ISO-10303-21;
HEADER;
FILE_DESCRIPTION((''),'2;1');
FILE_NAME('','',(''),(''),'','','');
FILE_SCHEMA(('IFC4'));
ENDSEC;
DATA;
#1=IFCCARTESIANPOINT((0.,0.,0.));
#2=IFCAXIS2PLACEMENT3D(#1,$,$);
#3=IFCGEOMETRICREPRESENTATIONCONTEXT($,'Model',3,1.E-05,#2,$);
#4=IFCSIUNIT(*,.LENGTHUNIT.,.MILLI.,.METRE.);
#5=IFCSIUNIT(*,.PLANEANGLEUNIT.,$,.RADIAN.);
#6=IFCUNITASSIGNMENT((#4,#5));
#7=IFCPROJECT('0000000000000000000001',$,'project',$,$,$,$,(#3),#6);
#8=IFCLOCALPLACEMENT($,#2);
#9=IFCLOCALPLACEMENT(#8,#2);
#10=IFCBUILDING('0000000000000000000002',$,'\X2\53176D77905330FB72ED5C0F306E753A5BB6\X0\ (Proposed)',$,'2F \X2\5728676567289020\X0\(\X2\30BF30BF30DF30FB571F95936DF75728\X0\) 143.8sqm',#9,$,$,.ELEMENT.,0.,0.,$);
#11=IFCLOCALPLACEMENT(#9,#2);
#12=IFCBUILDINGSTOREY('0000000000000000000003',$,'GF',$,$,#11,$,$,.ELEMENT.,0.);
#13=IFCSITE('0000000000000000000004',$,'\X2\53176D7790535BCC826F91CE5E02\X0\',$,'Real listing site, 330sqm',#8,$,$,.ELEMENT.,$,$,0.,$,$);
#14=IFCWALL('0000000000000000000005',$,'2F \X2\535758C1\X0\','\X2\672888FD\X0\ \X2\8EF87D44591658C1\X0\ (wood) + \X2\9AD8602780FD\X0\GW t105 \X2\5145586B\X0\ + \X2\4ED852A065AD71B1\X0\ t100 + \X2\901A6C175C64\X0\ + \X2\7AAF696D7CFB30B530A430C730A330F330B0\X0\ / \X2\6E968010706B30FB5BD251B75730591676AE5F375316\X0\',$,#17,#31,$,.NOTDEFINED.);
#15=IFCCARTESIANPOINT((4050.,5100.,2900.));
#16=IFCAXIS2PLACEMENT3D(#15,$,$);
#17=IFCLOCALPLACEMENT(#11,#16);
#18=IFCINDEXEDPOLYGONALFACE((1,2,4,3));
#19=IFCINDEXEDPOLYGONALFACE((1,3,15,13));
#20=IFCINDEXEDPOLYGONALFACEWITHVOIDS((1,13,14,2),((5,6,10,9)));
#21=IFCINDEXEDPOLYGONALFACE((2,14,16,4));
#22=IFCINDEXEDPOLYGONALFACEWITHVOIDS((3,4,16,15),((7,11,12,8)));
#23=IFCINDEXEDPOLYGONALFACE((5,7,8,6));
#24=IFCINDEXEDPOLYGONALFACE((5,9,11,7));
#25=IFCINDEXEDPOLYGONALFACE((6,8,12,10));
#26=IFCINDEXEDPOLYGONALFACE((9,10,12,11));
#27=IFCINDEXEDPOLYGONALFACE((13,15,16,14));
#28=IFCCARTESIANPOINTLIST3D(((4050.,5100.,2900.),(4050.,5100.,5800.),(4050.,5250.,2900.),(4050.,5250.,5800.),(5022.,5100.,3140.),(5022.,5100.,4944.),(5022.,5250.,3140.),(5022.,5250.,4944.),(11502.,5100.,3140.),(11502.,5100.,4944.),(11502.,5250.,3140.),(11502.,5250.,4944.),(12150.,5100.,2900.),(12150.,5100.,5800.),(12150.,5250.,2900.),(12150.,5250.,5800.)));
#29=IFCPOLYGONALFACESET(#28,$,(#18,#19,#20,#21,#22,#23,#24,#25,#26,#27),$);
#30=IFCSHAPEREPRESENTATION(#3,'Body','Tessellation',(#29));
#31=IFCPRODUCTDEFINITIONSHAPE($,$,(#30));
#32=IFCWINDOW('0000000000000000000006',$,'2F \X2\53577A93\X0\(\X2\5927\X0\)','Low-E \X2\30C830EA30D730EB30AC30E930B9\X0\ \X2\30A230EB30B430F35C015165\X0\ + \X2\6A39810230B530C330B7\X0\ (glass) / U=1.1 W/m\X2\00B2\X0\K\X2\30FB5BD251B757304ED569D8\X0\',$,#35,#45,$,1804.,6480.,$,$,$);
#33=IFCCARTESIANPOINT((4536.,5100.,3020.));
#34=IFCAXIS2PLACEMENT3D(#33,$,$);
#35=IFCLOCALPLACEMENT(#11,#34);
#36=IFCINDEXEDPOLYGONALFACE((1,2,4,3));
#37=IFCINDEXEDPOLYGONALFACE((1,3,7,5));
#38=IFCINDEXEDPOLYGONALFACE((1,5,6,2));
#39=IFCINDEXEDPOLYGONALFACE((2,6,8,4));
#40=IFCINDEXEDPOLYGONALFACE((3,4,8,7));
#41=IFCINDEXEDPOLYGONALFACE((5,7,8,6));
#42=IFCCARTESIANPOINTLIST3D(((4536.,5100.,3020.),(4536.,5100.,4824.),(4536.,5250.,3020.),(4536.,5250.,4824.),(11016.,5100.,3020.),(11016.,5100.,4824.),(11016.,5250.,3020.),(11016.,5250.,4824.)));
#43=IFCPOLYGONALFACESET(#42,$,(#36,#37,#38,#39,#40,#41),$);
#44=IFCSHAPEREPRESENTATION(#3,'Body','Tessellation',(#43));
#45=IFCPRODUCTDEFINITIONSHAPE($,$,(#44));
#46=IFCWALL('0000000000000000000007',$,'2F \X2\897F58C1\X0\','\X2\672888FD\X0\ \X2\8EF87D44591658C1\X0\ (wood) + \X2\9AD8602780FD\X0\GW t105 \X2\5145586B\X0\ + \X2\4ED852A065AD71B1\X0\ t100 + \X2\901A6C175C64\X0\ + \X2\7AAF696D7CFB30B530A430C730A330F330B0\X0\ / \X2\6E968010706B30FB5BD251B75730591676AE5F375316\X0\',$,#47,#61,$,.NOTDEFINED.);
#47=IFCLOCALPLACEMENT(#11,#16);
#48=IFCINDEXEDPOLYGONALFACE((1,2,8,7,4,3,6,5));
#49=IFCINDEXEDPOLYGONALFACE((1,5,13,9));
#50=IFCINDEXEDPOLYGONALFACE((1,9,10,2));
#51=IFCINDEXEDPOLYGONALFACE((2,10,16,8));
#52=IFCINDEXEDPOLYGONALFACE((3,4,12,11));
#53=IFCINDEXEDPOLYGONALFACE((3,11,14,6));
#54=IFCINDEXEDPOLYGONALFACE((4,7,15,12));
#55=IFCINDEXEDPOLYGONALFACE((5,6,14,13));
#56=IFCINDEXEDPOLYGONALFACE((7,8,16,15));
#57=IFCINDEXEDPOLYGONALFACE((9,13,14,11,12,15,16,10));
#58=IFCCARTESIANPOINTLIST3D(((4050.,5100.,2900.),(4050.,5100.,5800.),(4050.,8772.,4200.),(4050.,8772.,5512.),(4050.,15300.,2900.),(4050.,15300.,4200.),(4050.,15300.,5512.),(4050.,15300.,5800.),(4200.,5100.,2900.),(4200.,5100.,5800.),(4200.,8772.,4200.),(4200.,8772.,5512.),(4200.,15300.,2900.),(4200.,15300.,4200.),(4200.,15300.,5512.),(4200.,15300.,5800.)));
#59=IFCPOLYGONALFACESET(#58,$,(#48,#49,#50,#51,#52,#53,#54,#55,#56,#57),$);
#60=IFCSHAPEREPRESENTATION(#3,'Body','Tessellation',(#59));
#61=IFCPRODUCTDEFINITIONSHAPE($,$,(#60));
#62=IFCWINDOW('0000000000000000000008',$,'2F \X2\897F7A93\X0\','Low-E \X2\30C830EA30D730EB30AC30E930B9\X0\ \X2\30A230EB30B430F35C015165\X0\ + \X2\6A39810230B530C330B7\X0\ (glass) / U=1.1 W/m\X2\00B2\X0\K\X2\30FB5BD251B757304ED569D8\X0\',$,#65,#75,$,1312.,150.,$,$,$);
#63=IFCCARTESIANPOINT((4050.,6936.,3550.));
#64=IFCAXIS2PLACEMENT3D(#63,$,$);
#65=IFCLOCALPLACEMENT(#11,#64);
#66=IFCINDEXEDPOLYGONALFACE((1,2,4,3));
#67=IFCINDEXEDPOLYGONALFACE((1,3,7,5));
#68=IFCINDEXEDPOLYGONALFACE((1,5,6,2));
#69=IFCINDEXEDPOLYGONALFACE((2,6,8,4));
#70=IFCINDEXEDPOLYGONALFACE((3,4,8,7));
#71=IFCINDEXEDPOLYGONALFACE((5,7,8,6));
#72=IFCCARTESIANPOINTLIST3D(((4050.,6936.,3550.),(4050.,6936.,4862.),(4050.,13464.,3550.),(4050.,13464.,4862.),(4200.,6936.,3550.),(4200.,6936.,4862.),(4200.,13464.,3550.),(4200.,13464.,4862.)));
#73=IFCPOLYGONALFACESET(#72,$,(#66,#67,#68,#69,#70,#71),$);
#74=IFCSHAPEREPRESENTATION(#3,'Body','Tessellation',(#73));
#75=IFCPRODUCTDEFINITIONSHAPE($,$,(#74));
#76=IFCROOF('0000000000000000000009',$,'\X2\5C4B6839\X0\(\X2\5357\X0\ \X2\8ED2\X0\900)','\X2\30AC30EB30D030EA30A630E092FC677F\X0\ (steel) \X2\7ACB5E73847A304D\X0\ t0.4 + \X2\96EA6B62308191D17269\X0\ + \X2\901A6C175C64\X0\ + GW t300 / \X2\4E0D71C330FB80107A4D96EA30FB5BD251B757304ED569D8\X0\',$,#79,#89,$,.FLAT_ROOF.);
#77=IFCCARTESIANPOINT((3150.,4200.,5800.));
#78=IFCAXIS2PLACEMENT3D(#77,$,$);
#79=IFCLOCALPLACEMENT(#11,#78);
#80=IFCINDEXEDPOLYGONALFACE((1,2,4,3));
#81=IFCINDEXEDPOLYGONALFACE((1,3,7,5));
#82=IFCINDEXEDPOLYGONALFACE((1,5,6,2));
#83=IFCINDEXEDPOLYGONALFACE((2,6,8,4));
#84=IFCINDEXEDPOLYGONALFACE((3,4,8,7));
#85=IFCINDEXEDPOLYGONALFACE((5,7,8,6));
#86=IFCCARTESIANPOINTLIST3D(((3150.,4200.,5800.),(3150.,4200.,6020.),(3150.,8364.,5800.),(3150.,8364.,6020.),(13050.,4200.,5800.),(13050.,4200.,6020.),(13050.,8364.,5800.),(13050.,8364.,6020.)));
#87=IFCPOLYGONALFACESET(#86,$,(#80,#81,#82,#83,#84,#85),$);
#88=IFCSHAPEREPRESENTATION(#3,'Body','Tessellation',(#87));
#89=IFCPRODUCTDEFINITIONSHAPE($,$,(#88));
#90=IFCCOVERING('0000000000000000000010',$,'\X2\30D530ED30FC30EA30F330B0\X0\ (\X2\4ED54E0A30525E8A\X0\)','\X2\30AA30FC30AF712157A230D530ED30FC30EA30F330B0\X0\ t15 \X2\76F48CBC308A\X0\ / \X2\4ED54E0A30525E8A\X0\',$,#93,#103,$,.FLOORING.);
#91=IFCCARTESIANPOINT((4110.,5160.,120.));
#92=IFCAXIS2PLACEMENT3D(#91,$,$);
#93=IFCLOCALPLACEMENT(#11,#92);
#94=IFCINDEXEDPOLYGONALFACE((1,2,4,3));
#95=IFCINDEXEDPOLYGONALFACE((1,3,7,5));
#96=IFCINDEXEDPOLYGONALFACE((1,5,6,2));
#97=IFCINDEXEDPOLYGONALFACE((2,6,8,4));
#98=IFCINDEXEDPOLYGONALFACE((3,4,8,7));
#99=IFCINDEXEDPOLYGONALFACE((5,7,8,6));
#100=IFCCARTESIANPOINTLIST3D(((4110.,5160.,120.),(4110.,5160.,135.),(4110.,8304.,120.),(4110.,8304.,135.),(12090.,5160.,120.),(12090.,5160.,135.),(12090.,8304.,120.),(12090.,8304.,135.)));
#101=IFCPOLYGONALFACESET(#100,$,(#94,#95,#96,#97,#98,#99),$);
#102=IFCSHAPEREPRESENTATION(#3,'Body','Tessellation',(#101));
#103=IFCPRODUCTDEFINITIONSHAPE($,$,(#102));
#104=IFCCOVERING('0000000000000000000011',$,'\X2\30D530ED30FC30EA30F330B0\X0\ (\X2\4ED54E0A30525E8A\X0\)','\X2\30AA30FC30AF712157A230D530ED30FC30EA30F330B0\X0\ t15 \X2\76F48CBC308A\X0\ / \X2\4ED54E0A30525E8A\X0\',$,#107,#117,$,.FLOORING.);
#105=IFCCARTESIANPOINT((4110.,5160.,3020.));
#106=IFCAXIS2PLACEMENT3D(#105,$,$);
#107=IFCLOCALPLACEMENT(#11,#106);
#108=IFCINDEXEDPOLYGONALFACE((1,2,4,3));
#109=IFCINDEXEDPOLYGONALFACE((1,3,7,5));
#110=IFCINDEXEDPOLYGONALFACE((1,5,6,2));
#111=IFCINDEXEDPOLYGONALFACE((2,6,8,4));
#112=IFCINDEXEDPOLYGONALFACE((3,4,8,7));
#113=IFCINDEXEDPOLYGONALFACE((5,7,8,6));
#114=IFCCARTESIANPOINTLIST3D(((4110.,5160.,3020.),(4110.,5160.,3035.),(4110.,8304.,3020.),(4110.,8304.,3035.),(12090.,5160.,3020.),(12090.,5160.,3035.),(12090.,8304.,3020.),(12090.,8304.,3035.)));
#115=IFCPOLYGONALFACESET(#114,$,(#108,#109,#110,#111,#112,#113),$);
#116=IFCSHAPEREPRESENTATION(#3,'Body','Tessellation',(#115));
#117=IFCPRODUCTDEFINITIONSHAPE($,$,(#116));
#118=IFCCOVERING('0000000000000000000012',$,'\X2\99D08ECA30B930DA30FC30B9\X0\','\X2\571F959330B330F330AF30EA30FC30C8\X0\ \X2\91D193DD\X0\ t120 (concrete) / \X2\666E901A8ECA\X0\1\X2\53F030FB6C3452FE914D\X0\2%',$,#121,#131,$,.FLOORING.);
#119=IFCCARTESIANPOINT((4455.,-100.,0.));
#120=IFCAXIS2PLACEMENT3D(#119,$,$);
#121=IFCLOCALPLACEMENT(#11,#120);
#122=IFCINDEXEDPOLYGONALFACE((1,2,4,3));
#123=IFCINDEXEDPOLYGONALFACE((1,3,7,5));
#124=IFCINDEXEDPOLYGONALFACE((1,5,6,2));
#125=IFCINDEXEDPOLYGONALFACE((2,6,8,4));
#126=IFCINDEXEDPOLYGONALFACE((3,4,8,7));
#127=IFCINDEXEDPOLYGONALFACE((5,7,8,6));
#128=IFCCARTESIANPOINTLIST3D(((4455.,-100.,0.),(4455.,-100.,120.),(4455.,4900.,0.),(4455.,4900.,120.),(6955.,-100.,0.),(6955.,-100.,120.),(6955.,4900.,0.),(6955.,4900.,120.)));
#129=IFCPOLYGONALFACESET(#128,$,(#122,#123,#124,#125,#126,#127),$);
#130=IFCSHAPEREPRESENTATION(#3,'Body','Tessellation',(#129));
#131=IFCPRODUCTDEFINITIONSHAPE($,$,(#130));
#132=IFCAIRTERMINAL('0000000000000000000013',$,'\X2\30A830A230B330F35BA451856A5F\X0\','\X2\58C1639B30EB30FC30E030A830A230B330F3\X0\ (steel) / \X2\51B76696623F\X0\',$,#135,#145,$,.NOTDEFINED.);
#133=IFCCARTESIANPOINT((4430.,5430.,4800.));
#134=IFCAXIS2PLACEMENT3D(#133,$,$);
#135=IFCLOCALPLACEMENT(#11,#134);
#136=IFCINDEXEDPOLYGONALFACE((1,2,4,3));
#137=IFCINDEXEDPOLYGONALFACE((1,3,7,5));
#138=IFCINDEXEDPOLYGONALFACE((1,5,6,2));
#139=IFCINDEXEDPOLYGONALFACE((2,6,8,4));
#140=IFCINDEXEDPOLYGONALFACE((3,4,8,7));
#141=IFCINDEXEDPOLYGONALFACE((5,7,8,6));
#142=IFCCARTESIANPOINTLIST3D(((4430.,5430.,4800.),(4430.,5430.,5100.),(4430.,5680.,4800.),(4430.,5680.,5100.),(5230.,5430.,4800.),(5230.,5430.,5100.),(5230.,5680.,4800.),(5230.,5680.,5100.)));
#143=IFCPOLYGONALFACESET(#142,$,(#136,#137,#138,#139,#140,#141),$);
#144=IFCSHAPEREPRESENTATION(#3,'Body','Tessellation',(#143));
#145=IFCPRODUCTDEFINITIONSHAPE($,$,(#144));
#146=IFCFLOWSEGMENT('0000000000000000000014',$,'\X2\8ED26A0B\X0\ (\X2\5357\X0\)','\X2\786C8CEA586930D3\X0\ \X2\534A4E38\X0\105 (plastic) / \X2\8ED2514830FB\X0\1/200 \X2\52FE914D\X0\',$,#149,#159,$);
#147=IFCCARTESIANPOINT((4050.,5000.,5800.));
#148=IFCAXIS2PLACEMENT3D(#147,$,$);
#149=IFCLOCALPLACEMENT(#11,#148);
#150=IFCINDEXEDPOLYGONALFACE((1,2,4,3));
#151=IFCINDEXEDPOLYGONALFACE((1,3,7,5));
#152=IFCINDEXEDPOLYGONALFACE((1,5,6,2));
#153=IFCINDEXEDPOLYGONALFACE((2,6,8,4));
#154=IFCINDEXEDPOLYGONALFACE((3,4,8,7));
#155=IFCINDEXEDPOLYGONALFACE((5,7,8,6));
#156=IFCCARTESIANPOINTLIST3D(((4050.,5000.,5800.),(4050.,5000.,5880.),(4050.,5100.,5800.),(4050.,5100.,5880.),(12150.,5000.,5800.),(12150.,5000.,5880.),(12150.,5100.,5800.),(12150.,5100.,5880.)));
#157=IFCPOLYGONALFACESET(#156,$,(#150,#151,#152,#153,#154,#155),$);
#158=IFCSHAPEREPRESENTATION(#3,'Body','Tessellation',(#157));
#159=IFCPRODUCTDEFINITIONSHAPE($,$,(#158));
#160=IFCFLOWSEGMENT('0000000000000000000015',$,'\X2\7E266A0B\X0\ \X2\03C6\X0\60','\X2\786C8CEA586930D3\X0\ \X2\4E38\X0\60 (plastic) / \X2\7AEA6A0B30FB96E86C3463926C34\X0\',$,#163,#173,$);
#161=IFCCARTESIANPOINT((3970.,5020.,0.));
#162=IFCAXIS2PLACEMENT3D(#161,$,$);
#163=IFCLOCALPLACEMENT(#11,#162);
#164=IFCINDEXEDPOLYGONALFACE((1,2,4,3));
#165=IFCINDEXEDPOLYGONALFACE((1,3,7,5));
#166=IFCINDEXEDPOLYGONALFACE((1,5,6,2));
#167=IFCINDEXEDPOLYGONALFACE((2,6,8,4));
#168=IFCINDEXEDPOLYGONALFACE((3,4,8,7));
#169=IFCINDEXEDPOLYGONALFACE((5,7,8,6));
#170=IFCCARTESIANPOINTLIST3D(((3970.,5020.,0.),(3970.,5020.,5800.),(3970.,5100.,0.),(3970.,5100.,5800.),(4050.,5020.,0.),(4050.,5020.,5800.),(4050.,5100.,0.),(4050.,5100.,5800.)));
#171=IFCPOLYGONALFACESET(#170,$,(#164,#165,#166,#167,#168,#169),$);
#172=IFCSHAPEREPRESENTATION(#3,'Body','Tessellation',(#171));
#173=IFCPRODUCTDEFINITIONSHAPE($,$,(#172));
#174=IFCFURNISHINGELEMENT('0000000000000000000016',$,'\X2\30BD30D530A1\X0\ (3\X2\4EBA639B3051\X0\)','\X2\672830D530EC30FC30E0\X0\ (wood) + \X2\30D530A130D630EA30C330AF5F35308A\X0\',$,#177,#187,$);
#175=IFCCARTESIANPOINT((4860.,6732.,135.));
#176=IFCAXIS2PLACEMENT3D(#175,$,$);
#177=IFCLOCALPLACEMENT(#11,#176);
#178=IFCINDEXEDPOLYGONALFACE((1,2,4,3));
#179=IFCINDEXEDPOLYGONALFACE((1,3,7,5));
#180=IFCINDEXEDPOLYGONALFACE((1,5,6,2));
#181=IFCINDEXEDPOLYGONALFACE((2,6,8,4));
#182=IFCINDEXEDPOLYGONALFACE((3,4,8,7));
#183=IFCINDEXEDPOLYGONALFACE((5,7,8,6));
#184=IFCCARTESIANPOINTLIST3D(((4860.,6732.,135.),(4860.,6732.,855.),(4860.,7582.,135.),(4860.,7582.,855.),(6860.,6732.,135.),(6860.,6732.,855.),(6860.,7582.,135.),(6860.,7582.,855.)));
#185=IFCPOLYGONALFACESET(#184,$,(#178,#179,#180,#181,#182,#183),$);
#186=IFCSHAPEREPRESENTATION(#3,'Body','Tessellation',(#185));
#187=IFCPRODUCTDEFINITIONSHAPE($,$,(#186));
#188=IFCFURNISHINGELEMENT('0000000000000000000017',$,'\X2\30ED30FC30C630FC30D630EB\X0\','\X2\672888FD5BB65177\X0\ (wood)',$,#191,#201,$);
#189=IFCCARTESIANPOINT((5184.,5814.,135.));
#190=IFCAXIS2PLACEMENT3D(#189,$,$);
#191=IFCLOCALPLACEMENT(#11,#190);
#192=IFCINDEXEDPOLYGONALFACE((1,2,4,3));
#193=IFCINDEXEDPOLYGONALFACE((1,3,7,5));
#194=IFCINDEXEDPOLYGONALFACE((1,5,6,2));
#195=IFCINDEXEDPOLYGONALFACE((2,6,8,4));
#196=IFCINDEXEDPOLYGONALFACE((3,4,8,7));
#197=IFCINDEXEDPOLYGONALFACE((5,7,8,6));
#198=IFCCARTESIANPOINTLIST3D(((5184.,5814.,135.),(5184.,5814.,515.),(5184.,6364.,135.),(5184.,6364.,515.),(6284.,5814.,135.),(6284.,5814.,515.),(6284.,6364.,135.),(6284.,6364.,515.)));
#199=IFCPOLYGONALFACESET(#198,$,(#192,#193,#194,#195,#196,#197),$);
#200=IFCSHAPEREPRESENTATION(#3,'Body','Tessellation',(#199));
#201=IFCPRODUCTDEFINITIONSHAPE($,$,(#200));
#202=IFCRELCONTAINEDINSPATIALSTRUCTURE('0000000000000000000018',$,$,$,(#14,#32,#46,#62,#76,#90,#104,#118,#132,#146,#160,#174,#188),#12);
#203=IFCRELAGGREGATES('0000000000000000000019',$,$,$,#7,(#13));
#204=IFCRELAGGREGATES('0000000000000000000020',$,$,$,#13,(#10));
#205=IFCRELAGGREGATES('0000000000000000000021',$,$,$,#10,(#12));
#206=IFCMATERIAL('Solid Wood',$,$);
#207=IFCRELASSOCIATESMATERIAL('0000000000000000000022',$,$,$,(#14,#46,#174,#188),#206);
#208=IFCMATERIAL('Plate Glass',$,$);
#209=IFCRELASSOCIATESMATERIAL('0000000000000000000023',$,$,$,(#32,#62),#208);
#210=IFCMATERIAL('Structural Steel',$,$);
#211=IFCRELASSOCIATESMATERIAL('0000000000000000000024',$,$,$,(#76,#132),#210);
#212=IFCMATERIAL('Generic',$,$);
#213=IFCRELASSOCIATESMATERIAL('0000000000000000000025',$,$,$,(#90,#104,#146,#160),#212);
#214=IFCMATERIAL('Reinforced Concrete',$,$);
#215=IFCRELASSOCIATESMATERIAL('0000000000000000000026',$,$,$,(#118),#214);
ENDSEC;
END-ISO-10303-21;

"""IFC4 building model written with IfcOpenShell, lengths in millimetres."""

from ifc_helpers import new_model, si_unit, frame, frame_2d, origin, place, context, project, spatial, rectangle, extrude, material, element, fill, save


model = new_model("IFC4")

# Units and contexts
model_context = context("Model", 3, precision=1e-05, world=origin())
ifc_project = project(units=[si_unit("LENGTHUNIT", "METRE", prefix="MILLI"), si_unit("PLANEANGLEUNIT", "RADIAN")], contexts=[model_context])

# Site, building, storey
site_placement = place(None, origin())
site = spatial("IfcSite", under=ifc_project, at=site_placement, Name="北海道富良野市", ObjectType="Real listing site, 330sqm", CompositionType="ELEMENT", RefElevation=0.0)
building_placement = place(site_placement, origin())
building = spatial("IfcBuilding", under=site, at=building_placement, Name="北海道・狭小の町家 (Proposed)", ObjectType="2F 在来木造(タタミ・土間混在) 143.8sqm", CompositionType="ELEMENT", ElevationOfRefHeight=0.0, ElevationOfTerrain=0.0)
storey_placement = place(building_placement, origin())
storey = spatial("IfcBuildingStorey", under=building, at=storey_placement, Name="GF", CompositionType="ELEMENT", Elevation=0.0)

# Shared definitions
ifc_material_1 = material(Name="Solid Wood")

# Shared definitions
ifc_material_2 = material(Name="Reinforced Concrete")

# Shared definitions
ifc_material_3 = material(Name="Plate Glass")

# Walls, openings, windows
wall_1_placement = place(storey_placement, frame((4050.0, 5100.0, 2900.0)))
wall_1 = element("IfcWall", 1, at=wall_1_placement, inside=storey, material=ifc_material_1, Name="2F 南壁", Description="木製 軸組外壁 (wood) + 高性能GW t105 充填 + 付加断熱 t100 + 通気層 + 窯業系サイディング / 準耐火・寒冷地外皮強化", PredefinedType="NOTDEFINED", context=model_context, shape_type="SweptSolid", body=[
    extrude(rectangle(XDim=8100.0, YDim=150.0, at=frame_2d((4050.0, 75.0))), frame((4050.0, 5100.0, 2900.0)), (0.0, 0.0, 1.0), 2900.0),
])
opening_1_placement = place(storey_placement, frame((4536.0, 5100.0, 3020.0)))
opening_1 = element("IfcOpeningElement", 2, at=opening_1_placement, cuts=wall_1, PredefinedType="NOTDEFINED", context=model_context, shape_type="SweptSolid", body=[
    extrude(rectangle(XDim=6480.0, YDim=150.0, at=frame_2d((3240.0, 75.0))), frame((4536.0, 5100.0, 3020.0)), (0.0, 0.0, 1.0), 1804.0),
])
window_1_placement = place(storey_placement, frame((4536.0, 5100.0, 3020.0)))
window_1 = element("IfcWindow", 3, at=window_1_placement, inside=storey, material=ifc_material_3, Name="2F 南窓(大)", Description="Low-E トリプルガラス アルゴン封入 + 樹脂サッシ (glass) / U=1.1 W/m²K・寒冷地仕様", OverallHeight=1804.0, OverallWidth=6480.0, context=model_context, shape_type="SweptSolid", body=[
    extrude(rectangle(XDim=6480.0, YDim=150.0, at=frame_2d((3240.0, 75.0))), frame((4536.0, 5100.0, 3020.0)), (0.0, 0.0, 1.0), 1804.0),
])
fill(opening_1, window_1)
wall_2_placement = place(storey_placement, frame((4050.0, 5100.0, 2900.0)))
wall_2 = element("IfcWall", 4, at=wall_2_placement, inside=storey, material=ifc_material_1, Name="2F 西壁", Description="木製 軸組外壁 (wood) + 高性能GW t105 充填 + 付加断熱 t100 + 通気層 + 窯業系サイディング / 準耐火・寒冷地外皮強化", PredefinedType="NOTDEFINED", context=model_context, shape_type="SweptSolid", body=[
    extrude(rectangle(XDim=150.0, YDim=10200.0, at=frame_2d((75.0, 5100.0))), frame((4050.0, 5100.0, 2900.0)), (0.0, 0.0, 1.0), 2900.0),
])
opening_2_placement = place(storey_placement, frame((4050.0, 6936.0, 3550.0)))
opening_2 = element("IfcOpeningElement", 5, at=opening_2_placement, cuts=wall_2, PredefinedType="NOTDEFINED", context=model_context, shape_type="SweptSolid", body=[
    extrude(rectangle(XDim=150.0, YDim=6528.0, at=frame_2d((75.0, 3264.0))), frame((4050.0, 6936.0, 3550.0)), (0.0, 0.0, 1.0), 1312.0),
])
window_2_placement = place(storey_placement, frame((4050.0, 6936.0, 3550.0)))
window_2 = element("IfcWindow", 6, at=window_2_placement, inside=storey, material=ifc_material_3, Name="2F 西窓", Description="Low-E トリプルガラス アルゴン封入 + 樹脂サッシ (glass) / U=1.1 W/m²K・寒冷地仕様", OverallHeight=1312.0, OverallWidth=150.0, context=model_context, shape_type="SweptSolid", body=[
    extrude(rectangle(XDim=150.0, YDim=6528.0, at=frame_2d((75.0, 3264.0))), frame((4050.0, 6936.0, 3550.0)), (0.0, 0.0, 1.0), 1312.0),
])
fill(opening_2, window_2)

# Roof
ifc_material_4 = material(Name="Structural Steel")
for number, where, name in (
    (7, (3150.0, 4200.0, 5800.0), "屋根(南 軒900)"),
):
    element("IfcRoof", number, at=place(storey_placement, frame(where)), inside=storey, material=ifc_material_4, Name=name, Description="ガルバリウム鋼板 (steel) 立平葺き t0.4 + 雪止め金物 + 通気層 + GW t300 / 不燃・耐積雪・寒冷地仕様", PredefinedType="FLAT_ROOF", context=model_context, shape_type="SweptSolid", body=[
        extrude(rectangle(XDim=9900.0, YDim=4164.0, at=frame_2d((4950.0, 2082.0))), frame((3150.0, 4200.0, 5800.0)), (0.0, 0.0, 1.0), 220.0),
    ])

# Coverings
ifc_material_5 = material(Name="Generic")
covering_1_placement = place(storey_placement, frame((4110.0, 5160.0, 120.0)))
element("IfcCovering", 8, at=covering_1_placement, inside=storey, material=ifc_material_5, Name="フローリング (仕上げ床)", Description="オーク無垢フローリング t15 直貼り / 仕上げ床", PredefinedType="FLOORING", context=model_context, shape_type="SweptSolid", body=[
    extrude(rectangle(XDim=7980.0, YDim=3144.0, at=frame_2d((3990.0, 1572.0))), frame((4110.0, 5160.0, 120.0)), (0.0, 0.0, 1.0), 15.0),
])
covering_2_placement = place(storey_placement, frame((4110.0, 5160.0, 3020.0)))
element("IfcCovering", 9, at=covering_2_placement, inside=storey, material=ifc_material_5, Name="フローリング (仕上げ床)", Description="オーク無垢フローリング t15 直貼り / 仕上げ床", PredefinedType="FLOORING", context=model_context, shape_type="SweptSolid", body=[
    extrude(rectangle(XDim=7980.0, YDim=3144.0, at=frame_2d((3990.0, 1572.0))), frame((4110.0, 5160.0, 3020.0)), (0.0, 0.0, 1.0), 15.0),
])
covering_3_placement = place(storey_placement, frame((4455.0, -100.0, 0.0)))
element("IfcCovering", 10, at=covering_3_placement, inside=storey, material=ifc_material_2, Name="駐車スペース", Description="土間コンクリート 金鏝 t120 (concrete) / 普通車1台・水勾配2%", PredefinedType="FLOORING", context=model_context, shape_type="SweptSolid", body=[
    extrude(rectangle(XDim=2500.0, YDim=5000.0, at=frame_2d((1250.0, 2500.0))), frame((4455.0, -100.0, 0.0)), (0.0, 0.0, 1.0), 120.0),
])

# Air terminal
air_terminal_placement = place(storey_placement, frame((4430.0, 5430.0, 4800.0)))
element("IfcAirTerminal", 11, at=air_terminal_placement, inside=storey, material=ifc_material_4, Name="エアコン室内機", Description="壁掛ルームエアコン (steel) / 冷暖房", PredefinedType="NOTDEFINED", context=model_context, shape_type="SweptSolid", body=[
    extrude(rectangle(XDim=800.0, YDim=250.0, at=frame_2d((400.0, 125.0))), frame((4430.0, 5430.0, 4800.0)), (0.0, 0.0, 1.0), 300.0),
])

# Flow segments
flow_segment_1_placement = place(storey_placement, frame((4050.0, 5000.0, 5800.0)))
element("IfcFlowSegment", 12, at=flow_segment_1_placement, inside=storey, material=ifc_material_5, Name="軒樋 (南)", Description="硬質塩ビ 半丸105 (plastic) / 軒先・1/200 勾配", context=model_context, shape_type="SweptSolid", body=[
    extrude(rectangle(XDim=8100.0, YDim=100.0, at=frame_2d((4050.0, 50.0))), frame((4050.0, 5000.0, 5800.0)), (0.0, 0.0, 1.0), 80.0),
])
flow_segment_2_placement = place(storey_placement, frame((3970.0, 5020.0, 0.0)))
element("IfcFlowSegment", 13, at=flow_segment_2_placement, inside=storey, material=ifc_material_5, Name="縦樋 φ60", Description="硬質塩ビ 丸60 (plastic) / 竪樋・雨水排水", context=model_context, shape_type="SweptSolid", body=[
    extrude(rectangle(XDim=80.0, YDim=80.0, at=frame_2d((40.0, 40.0))), frame((3970.0, 5020.0, 0.0)), (0.0, 0.0, 1.0), 5800.0),
])

# Furnishing elements
furnishing_1_placement = place(storey_placement, frame((4860.0, 6732.0, 135.0)))
element("IfcFurnishingElement", 14, at=furnishing_1_placement, inside=storey, material=ifc_material_1, Name="ソファ (3人掛け)", Description="木フレーム (wood) + ファブリック張り", context=model_context, shape_type="SweptSolid", body=[
    extrude(rectangle(XDim=2000.0, YDim=850.0, at=frame_2d((1000.0, 425.0))), frame((4860.0, 6732.0, 135.0)), (0.0, 0.0, 1.0), 720.0),
])
furnishing_2_placement = place(storey_placement, frame((5184.0, 5814.0, 135.0)))
element("IfcFurnishingElement", 15, at=furnishing_2_placement, inside=storey, material=ifc_material_1, Name="ローテーブル", Description="木製家具 (wood)", context=model_context, shape_type="SweptSolid", body=[
    extrude(rectangle(XDim=1100.0, YDim=550.0, at=frame_2d((550.0, 275.0))), frame((5184.0, 5814.0, 135.0)), (0.0, 0.0, 1.0), 380.0),
])

save(model, "model.ifc")
